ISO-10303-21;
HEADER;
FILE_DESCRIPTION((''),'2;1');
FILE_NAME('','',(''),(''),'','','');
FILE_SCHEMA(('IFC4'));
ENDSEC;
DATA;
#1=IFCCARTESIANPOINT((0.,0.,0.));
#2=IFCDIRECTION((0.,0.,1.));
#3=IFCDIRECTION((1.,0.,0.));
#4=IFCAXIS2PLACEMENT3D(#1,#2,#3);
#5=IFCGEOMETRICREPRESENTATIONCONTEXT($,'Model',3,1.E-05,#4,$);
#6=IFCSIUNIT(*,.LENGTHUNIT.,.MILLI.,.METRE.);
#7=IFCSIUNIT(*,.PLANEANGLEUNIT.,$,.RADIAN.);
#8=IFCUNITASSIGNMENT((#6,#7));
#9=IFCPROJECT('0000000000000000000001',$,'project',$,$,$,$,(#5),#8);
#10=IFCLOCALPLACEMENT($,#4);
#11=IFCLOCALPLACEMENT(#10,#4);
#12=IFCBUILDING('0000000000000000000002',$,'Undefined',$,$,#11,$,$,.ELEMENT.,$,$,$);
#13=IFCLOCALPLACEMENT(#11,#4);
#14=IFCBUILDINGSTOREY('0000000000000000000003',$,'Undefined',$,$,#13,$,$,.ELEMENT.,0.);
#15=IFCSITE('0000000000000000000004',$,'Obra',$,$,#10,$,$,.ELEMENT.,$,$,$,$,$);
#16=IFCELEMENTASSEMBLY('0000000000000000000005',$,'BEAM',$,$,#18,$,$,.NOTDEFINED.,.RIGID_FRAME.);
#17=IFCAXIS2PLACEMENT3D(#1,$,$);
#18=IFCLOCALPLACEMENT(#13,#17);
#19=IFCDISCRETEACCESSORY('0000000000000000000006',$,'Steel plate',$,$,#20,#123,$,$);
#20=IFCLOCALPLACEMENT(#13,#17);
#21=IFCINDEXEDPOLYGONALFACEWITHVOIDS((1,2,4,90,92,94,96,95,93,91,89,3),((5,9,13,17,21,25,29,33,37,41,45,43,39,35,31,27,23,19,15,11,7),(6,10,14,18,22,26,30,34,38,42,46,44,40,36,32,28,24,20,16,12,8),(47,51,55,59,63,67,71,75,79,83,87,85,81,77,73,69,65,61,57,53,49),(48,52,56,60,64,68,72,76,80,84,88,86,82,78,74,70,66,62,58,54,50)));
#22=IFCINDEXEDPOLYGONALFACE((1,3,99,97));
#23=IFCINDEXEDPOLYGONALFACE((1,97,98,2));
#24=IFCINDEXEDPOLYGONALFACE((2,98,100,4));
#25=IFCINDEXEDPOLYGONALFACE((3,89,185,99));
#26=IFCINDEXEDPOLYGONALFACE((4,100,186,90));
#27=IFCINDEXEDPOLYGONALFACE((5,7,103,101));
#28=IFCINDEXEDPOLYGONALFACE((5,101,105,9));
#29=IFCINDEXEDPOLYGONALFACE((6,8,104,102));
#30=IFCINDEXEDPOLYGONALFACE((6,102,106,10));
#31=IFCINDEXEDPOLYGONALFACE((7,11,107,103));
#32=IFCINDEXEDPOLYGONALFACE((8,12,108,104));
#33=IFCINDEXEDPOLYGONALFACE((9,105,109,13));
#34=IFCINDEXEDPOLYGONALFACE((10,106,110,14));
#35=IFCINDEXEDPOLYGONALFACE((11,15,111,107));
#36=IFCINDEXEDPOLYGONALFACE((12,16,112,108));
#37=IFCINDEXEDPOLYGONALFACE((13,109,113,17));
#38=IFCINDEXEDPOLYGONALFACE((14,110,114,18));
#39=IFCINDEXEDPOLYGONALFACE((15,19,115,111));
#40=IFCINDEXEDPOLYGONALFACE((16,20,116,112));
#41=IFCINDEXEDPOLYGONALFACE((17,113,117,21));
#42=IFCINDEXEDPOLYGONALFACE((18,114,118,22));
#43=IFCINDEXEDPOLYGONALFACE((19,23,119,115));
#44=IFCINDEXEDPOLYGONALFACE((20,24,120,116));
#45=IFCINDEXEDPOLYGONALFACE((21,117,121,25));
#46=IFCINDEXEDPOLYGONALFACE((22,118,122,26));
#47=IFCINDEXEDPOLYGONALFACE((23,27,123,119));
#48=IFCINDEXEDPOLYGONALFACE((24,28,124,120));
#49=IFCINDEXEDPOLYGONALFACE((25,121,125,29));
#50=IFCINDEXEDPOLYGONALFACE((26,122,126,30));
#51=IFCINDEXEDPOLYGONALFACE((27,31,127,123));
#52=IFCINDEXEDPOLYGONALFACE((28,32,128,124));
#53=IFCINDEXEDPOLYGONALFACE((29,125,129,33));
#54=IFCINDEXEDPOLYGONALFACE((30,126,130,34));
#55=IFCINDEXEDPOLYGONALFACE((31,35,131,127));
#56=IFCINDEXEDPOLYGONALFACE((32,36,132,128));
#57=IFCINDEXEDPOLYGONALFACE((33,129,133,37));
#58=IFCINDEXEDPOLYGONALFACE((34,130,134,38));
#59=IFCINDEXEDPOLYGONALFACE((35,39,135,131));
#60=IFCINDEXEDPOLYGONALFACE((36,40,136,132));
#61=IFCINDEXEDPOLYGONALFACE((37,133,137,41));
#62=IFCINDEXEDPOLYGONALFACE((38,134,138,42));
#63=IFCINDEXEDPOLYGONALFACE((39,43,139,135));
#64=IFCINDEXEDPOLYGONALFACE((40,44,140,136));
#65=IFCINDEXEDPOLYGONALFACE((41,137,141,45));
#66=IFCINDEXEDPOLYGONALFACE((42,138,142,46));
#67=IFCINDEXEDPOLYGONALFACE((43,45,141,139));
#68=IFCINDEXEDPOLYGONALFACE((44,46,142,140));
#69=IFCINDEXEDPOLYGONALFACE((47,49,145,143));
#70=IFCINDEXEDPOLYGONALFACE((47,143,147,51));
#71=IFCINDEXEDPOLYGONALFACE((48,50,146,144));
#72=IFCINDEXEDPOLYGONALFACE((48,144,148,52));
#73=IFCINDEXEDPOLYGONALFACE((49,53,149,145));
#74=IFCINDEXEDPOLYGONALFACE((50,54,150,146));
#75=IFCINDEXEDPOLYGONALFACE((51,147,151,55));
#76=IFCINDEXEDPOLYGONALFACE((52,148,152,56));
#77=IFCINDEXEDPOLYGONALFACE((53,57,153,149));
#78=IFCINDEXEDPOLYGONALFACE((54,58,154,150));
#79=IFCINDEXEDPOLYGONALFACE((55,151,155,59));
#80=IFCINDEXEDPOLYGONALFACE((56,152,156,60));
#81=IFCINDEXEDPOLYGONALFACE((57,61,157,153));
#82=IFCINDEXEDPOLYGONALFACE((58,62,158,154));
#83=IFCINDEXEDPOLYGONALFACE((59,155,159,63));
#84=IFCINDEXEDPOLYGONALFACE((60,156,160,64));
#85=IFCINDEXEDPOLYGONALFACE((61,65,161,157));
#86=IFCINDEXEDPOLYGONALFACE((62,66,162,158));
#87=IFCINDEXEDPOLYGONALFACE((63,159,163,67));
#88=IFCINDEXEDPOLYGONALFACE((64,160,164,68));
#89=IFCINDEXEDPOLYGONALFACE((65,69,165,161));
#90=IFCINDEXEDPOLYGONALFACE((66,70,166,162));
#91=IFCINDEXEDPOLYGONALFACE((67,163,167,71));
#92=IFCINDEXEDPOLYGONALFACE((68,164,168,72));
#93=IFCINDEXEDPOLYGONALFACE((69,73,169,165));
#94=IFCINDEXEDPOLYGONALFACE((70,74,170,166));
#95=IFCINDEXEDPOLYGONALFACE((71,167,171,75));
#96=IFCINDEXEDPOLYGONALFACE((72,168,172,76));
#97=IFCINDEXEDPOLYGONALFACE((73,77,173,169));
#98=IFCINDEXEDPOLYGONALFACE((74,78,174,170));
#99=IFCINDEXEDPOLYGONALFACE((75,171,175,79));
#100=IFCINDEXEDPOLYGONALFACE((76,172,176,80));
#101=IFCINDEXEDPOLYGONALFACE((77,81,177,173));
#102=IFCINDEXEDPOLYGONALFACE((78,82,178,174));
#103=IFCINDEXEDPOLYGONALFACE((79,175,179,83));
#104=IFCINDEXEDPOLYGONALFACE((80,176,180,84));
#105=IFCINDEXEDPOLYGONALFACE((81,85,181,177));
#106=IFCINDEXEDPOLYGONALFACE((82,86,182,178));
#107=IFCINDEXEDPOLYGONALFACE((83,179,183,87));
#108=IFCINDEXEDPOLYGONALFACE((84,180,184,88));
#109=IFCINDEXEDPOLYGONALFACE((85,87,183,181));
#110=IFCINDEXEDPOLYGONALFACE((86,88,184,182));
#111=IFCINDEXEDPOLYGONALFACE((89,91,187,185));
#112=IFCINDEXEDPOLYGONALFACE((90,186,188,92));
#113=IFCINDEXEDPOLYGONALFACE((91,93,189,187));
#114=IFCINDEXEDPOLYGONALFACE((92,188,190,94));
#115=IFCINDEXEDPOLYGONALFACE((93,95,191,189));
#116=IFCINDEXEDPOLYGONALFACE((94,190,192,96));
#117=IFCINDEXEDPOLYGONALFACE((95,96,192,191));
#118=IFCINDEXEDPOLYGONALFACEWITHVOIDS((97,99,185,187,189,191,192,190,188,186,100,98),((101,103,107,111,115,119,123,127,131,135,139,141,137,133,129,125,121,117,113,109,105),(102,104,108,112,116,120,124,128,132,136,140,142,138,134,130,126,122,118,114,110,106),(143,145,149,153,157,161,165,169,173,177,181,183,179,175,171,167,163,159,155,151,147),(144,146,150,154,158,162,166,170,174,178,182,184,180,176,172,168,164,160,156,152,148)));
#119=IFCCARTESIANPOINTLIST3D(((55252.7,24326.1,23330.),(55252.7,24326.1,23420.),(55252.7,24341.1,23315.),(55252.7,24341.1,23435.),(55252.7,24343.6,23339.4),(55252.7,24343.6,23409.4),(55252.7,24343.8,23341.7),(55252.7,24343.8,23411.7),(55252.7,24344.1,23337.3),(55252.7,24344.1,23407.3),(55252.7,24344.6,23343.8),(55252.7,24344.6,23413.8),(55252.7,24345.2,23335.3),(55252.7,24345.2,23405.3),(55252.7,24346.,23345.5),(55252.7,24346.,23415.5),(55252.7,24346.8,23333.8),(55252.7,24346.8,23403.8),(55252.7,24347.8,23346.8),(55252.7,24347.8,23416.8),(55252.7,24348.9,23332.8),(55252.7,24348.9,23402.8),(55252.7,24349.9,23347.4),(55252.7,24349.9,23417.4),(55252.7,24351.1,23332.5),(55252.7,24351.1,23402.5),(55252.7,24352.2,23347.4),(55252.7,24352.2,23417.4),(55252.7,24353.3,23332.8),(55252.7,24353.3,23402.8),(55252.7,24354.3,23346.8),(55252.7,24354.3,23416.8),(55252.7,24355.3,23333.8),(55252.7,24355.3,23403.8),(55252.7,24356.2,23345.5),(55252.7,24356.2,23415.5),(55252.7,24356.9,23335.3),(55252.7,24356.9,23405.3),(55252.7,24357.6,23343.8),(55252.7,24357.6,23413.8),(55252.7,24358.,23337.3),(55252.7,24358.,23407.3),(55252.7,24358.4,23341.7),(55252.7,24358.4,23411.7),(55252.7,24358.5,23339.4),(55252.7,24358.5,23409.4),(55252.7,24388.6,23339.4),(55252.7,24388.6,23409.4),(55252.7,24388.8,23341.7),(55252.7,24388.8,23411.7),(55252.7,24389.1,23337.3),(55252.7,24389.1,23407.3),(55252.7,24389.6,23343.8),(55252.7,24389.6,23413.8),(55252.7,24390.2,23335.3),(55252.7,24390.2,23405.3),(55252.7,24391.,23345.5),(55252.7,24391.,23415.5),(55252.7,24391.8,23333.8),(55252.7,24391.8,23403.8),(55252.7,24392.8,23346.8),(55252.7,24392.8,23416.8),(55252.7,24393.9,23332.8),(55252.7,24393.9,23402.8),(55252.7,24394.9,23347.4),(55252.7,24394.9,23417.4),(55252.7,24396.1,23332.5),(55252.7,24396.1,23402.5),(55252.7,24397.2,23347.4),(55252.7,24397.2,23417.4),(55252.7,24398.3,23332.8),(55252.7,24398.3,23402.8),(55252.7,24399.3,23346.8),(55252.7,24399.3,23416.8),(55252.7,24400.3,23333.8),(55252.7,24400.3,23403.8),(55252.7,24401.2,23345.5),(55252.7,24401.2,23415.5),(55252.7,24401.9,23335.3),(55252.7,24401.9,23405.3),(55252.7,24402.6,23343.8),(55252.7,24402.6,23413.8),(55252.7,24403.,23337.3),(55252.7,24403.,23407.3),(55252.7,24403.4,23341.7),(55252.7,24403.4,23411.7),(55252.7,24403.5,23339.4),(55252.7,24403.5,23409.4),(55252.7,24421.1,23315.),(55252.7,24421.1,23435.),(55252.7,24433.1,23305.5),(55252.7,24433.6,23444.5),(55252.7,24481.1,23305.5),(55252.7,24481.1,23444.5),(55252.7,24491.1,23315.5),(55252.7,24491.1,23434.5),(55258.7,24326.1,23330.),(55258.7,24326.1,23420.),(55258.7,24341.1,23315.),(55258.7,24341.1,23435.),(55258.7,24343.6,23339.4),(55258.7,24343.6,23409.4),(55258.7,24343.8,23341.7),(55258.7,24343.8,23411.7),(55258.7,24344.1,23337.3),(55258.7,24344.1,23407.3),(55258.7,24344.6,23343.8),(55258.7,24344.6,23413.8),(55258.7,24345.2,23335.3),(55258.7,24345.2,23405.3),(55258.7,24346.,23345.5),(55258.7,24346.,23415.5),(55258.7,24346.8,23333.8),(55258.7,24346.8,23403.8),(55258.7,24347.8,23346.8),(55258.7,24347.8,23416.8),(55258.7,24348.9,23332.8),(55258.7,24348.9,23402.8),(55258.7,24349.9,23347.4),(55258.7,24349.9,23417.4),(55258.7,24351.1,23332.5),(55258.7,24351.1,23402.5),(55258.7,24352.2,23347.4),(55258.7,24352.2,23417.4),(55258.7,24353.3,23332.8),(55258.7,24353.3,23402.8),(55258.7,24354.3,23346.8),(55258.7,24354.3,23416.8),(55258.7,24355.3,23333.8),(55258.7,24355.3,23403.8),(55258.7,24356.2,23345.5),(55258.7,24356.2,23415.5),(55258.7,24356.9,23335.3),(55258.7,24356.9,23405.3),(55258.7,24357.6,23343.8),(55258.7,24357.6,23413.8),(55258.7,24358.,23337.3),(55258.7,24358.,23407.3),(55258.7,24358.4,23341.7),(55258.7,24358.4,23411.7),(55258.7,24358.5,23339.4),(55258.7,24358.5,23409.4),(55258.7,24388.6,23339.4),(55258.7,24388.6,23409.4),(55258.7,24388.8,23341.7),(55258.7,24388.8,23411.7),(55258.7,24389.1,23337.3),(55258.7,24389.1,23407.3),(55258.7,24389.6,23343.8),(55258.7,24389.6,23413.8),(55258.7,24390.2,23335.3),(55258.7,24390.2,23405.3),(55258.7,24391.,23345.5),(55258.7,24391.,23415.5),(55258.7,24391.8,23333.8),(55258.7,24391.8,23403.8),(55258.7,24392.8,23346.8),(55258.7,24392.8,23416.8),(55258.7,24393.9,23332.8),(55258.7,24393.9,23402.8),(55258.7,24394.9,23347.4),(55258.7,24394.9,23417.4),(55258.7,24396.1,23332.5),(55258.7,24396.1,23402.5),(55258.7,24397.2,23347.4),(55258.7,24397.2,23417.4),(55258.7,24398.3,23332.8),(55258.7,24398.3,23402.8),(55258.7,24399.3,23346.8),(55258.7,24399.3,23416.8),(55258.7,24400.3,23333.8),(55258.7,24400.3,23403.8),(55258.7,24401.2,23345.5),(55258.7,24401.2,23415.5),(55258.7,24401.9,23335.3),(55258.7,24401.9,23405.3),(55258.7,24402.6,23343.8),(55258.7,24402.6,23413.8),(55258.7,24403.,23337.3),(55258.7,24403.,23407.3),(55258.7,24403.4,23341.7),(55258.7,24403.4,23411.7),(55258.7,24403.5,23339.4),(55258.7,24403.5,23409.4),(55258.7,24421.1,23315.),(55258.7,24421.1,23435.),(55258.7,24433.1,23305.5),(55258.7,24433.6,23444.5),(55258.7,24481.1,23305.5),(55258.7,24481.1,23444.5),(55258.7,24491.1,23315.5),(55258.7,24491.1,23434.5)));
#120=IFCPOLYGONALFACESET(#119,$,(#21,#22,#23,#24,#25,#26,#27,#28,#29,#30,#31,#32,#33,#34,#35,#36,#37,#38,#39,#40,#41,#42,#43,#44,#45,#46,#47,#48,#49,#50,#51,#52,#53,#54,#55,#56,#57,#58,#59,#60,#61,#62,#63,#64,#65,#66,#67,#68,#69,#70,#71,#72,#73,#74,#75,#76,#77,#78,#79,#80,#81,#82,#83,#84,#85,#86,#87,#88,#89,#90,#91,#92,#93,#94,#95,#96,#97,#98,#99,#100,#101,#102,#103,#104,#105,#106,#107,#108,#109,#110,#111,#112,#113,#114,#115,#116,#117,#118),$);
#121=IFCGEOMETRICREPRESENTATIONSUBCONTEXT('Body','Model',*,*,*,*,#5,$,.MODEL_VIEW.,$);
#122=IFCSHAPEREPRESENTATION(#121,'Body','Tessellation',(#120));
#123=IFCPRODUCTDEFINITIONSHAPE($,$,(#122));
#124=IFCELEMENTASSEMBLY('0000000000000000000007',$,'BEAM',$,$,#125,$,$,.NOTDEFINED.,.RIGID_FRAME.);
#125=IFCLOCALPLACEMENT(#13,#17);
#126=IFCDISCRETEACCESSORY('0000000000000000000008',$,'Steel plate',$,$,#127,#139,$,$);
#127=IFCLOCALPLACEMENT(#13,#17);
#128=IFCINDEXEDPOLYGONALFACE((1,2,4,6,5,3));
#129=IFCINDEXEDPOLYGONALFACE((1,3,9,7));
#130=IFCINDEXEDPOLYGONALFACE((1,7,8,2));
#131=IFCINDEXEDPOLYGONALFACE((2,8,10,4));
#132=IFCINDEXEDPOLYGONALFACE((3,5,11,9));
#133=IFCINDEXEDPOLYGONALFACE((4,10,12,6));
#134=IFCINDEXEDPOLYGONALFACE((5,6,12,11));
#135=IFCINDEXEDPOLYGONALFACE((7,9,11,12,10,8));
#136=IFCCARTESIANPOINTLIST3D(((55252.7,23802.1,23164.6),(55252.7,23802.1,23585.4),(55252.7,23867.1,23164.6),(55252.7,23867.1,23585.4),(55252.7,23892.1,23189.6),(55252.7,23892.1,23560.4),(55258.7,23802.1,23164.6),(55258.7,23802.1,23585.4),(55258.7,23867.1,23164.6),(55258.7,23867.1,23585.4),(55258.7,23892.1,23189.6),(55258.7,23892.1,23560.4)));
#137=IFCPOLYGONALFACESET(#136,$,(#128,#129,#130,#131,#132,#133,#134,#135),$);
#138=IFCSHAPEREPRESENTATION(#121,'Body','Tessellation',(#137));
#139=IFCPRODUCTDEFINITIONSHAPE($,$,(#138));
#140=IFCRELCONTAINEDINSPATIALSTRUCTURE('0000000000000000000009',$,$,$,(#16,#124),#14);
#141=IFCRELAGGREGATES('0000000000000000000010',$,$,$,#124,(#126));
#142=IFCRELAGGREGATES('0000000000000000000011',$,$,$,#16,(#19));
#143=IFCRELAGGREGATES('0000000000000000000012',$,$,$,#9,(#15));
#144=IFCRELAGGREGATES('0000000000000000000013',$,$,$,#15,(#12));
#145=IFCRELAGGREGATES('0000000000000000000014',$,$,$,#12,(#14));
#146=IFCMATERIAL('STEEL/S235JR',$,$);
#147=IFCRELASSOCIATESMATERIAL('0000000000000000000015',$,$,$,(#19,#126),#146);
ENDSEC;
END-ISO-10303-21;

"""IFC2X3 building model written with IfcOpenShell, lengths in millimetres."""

from ifc_helpers import new_model, si_unit, frame, origin_with_axes, origin_2d_with_axis, place, context, subcontext, project, spatial, polyline, circle, outline, extrude, source, transform, mapped, material, element, aggregate, save


model = new_model("IFC2X3")

# Units and contexts
model_context = context("Model", 3, precision=1e-05, world=origin_with_axes())
body_context = subcontext(model_context, "Body", "Model", "MODEL_VIEW")
ifc_project = project(units=[si_unit("LENGTHUNIT", "METRE", prefix="MILLI"), si_unit("PLANEANGLEUNIT", "RADIAN")], contexts=[model_context])

# Site, building, storey
site_placement = place(None, origin_with_axes())
site = spatial("IfcSite", under=ifc_project, at=site_placement, Name="Obra", CompositionType="ELEMENT")
building_placement = place(site_placement, origin_with_axes())
building = spatial("IfcBuilding", under=site, at=building_placement, Name="Undefined", CompositionType="ELEMENT")
storey_placement = place(building_placement, origin_with_axes())
storey = spatial("IfcBuildingStorey", under=building, at=storey_placement, Name="Undefined", CompositionType="ELEMENT", Elevation=0.0)

# Shared definitions
ifc_material_1 = material(Name="STEEL/S235JR")

# Element assembly
assembly_1_placement = place(storey_placement, origin_with_axes())
assembly_1 = element("IfcElementAssembly", 1, at=assembly_1_placement, inside=storey, Name="BEAM", AssemblyPlace="NOTDEFINED", PredefinedType="RIGID_FRAME")

# Discrete accessory, opening
discrete_accessory_1_placement = place(assembly_1_placement, frame((55255.7, 24491.1, 23315.5), z_axis=(-1.0, 0.0, 0.0), x_axis=(0.000001, -0.707107, -0.707107)))
discrete_accessory_1 = element("IfcDiscreteAccessory", 2, at=discrete_accessory_1_placement, material=ifc_material_1, Name="Steel plate", context=body_context, shape_type="SweptSolid", body=[
    extrude(outline(polyline([(0.0, 0.0), (14.1, 0.0), (48.1, 33.9), (49.9, 49.1), (106.4, 105.7), (106.4, 126.9), (42.8, 190.6), (21.6, 190.6), (-35.0, 134.0), (-50.6, 131.9), (-84.1, 98.3), (-84.1, 84.1), (0.0, 0.0)])), frame((0.0, 0.0, -3.0), z_axis=(0.0, 0.0, 1.0), x_axis=(1.0, 0.0, 0.0)), (0.0, 0.0, 1.0), 6.0),
])
shared_shape_1 = source(origin_with_axes(), body_context, "Body", "SweptSolid", [
    extrude(circle(Radius=7.5, at=origin_2d_with_axis()), frame((0.0, 2.4, 0.0), z_axis=(0.0, 1.0, 0.0), x_axis=(1.0, 0.0, 0.0)), (0.0, 0.0, 1.0), 6.2),
])
opening_1_placement = place(assembly_1_placement, frame((55250.2, 24373.6, 23410.0), z_axis=(0.0, -1.0, 0.0), x_axis=(0.0, 0.0, -1.0)))
element("IfcOpeningElement", 3, at=opening_1_placement, cuts=discrete_accessory_1, ObjectType="Opening", context=body_context, shape_type="MappedRepresentation", body=[
    mapped(shared_shape_1, transform((0.0, 0.0, -22.5))),
    mapped(shared_shape_1, transform((70.0, 0.0, -22.5))),
    mapped(shared_shape_1, transform((0.0, 0.0, 22.5))),
    mapped(shared_shape_1, transform((70.0, 0.0, 22.5))),
])

# Element assembly, discrete accessory
assembly_2_placement = place(storey_placement, origin_with_axes())
assembly_2 = element("IfcElementAssembly", 4, at=assembly_2_placement, inside=storey, Name="BEAM", AssemblyPlace="NOTDEFINED", PredefinedType="RIGID_FRAME")
discrete_accessory_2_placement = place(assembly_2_placement, frame((55255.7, 23892.1, 23164.6), z_axis=(-1.0, 0.0, 0.0), x_axis=(0.0, -1.0, 0.0)))
discrete_accessory_2 = element("IfcDiscreteAccessory", 5, at=discrete_accessory_2_placement, material=ifc_material_1, Name="Steel plate", context=body_context, shape_type="SweptSolid", body=[
    extrude(outline(polyline([(0.0, 25.0), (25.0, 0.0), (90.0, 0.0), (90.0, 420.8), (25.0, 420.8), (0.0, 395.8), (0.0, 25.0)])), frame((0.0, 0.0, -3.0), z_axis=(0.0, 0.0, 1.0), x_axis=(1.0, 0.0, 0.0)), (0.0, 0.0, 1.0), 6.0),
])

aggregate(assembly_2, [discrete_accessory_2])

aggregate(assembly_1, [discrete_accessory_1])

save(model, "model.ifc")
